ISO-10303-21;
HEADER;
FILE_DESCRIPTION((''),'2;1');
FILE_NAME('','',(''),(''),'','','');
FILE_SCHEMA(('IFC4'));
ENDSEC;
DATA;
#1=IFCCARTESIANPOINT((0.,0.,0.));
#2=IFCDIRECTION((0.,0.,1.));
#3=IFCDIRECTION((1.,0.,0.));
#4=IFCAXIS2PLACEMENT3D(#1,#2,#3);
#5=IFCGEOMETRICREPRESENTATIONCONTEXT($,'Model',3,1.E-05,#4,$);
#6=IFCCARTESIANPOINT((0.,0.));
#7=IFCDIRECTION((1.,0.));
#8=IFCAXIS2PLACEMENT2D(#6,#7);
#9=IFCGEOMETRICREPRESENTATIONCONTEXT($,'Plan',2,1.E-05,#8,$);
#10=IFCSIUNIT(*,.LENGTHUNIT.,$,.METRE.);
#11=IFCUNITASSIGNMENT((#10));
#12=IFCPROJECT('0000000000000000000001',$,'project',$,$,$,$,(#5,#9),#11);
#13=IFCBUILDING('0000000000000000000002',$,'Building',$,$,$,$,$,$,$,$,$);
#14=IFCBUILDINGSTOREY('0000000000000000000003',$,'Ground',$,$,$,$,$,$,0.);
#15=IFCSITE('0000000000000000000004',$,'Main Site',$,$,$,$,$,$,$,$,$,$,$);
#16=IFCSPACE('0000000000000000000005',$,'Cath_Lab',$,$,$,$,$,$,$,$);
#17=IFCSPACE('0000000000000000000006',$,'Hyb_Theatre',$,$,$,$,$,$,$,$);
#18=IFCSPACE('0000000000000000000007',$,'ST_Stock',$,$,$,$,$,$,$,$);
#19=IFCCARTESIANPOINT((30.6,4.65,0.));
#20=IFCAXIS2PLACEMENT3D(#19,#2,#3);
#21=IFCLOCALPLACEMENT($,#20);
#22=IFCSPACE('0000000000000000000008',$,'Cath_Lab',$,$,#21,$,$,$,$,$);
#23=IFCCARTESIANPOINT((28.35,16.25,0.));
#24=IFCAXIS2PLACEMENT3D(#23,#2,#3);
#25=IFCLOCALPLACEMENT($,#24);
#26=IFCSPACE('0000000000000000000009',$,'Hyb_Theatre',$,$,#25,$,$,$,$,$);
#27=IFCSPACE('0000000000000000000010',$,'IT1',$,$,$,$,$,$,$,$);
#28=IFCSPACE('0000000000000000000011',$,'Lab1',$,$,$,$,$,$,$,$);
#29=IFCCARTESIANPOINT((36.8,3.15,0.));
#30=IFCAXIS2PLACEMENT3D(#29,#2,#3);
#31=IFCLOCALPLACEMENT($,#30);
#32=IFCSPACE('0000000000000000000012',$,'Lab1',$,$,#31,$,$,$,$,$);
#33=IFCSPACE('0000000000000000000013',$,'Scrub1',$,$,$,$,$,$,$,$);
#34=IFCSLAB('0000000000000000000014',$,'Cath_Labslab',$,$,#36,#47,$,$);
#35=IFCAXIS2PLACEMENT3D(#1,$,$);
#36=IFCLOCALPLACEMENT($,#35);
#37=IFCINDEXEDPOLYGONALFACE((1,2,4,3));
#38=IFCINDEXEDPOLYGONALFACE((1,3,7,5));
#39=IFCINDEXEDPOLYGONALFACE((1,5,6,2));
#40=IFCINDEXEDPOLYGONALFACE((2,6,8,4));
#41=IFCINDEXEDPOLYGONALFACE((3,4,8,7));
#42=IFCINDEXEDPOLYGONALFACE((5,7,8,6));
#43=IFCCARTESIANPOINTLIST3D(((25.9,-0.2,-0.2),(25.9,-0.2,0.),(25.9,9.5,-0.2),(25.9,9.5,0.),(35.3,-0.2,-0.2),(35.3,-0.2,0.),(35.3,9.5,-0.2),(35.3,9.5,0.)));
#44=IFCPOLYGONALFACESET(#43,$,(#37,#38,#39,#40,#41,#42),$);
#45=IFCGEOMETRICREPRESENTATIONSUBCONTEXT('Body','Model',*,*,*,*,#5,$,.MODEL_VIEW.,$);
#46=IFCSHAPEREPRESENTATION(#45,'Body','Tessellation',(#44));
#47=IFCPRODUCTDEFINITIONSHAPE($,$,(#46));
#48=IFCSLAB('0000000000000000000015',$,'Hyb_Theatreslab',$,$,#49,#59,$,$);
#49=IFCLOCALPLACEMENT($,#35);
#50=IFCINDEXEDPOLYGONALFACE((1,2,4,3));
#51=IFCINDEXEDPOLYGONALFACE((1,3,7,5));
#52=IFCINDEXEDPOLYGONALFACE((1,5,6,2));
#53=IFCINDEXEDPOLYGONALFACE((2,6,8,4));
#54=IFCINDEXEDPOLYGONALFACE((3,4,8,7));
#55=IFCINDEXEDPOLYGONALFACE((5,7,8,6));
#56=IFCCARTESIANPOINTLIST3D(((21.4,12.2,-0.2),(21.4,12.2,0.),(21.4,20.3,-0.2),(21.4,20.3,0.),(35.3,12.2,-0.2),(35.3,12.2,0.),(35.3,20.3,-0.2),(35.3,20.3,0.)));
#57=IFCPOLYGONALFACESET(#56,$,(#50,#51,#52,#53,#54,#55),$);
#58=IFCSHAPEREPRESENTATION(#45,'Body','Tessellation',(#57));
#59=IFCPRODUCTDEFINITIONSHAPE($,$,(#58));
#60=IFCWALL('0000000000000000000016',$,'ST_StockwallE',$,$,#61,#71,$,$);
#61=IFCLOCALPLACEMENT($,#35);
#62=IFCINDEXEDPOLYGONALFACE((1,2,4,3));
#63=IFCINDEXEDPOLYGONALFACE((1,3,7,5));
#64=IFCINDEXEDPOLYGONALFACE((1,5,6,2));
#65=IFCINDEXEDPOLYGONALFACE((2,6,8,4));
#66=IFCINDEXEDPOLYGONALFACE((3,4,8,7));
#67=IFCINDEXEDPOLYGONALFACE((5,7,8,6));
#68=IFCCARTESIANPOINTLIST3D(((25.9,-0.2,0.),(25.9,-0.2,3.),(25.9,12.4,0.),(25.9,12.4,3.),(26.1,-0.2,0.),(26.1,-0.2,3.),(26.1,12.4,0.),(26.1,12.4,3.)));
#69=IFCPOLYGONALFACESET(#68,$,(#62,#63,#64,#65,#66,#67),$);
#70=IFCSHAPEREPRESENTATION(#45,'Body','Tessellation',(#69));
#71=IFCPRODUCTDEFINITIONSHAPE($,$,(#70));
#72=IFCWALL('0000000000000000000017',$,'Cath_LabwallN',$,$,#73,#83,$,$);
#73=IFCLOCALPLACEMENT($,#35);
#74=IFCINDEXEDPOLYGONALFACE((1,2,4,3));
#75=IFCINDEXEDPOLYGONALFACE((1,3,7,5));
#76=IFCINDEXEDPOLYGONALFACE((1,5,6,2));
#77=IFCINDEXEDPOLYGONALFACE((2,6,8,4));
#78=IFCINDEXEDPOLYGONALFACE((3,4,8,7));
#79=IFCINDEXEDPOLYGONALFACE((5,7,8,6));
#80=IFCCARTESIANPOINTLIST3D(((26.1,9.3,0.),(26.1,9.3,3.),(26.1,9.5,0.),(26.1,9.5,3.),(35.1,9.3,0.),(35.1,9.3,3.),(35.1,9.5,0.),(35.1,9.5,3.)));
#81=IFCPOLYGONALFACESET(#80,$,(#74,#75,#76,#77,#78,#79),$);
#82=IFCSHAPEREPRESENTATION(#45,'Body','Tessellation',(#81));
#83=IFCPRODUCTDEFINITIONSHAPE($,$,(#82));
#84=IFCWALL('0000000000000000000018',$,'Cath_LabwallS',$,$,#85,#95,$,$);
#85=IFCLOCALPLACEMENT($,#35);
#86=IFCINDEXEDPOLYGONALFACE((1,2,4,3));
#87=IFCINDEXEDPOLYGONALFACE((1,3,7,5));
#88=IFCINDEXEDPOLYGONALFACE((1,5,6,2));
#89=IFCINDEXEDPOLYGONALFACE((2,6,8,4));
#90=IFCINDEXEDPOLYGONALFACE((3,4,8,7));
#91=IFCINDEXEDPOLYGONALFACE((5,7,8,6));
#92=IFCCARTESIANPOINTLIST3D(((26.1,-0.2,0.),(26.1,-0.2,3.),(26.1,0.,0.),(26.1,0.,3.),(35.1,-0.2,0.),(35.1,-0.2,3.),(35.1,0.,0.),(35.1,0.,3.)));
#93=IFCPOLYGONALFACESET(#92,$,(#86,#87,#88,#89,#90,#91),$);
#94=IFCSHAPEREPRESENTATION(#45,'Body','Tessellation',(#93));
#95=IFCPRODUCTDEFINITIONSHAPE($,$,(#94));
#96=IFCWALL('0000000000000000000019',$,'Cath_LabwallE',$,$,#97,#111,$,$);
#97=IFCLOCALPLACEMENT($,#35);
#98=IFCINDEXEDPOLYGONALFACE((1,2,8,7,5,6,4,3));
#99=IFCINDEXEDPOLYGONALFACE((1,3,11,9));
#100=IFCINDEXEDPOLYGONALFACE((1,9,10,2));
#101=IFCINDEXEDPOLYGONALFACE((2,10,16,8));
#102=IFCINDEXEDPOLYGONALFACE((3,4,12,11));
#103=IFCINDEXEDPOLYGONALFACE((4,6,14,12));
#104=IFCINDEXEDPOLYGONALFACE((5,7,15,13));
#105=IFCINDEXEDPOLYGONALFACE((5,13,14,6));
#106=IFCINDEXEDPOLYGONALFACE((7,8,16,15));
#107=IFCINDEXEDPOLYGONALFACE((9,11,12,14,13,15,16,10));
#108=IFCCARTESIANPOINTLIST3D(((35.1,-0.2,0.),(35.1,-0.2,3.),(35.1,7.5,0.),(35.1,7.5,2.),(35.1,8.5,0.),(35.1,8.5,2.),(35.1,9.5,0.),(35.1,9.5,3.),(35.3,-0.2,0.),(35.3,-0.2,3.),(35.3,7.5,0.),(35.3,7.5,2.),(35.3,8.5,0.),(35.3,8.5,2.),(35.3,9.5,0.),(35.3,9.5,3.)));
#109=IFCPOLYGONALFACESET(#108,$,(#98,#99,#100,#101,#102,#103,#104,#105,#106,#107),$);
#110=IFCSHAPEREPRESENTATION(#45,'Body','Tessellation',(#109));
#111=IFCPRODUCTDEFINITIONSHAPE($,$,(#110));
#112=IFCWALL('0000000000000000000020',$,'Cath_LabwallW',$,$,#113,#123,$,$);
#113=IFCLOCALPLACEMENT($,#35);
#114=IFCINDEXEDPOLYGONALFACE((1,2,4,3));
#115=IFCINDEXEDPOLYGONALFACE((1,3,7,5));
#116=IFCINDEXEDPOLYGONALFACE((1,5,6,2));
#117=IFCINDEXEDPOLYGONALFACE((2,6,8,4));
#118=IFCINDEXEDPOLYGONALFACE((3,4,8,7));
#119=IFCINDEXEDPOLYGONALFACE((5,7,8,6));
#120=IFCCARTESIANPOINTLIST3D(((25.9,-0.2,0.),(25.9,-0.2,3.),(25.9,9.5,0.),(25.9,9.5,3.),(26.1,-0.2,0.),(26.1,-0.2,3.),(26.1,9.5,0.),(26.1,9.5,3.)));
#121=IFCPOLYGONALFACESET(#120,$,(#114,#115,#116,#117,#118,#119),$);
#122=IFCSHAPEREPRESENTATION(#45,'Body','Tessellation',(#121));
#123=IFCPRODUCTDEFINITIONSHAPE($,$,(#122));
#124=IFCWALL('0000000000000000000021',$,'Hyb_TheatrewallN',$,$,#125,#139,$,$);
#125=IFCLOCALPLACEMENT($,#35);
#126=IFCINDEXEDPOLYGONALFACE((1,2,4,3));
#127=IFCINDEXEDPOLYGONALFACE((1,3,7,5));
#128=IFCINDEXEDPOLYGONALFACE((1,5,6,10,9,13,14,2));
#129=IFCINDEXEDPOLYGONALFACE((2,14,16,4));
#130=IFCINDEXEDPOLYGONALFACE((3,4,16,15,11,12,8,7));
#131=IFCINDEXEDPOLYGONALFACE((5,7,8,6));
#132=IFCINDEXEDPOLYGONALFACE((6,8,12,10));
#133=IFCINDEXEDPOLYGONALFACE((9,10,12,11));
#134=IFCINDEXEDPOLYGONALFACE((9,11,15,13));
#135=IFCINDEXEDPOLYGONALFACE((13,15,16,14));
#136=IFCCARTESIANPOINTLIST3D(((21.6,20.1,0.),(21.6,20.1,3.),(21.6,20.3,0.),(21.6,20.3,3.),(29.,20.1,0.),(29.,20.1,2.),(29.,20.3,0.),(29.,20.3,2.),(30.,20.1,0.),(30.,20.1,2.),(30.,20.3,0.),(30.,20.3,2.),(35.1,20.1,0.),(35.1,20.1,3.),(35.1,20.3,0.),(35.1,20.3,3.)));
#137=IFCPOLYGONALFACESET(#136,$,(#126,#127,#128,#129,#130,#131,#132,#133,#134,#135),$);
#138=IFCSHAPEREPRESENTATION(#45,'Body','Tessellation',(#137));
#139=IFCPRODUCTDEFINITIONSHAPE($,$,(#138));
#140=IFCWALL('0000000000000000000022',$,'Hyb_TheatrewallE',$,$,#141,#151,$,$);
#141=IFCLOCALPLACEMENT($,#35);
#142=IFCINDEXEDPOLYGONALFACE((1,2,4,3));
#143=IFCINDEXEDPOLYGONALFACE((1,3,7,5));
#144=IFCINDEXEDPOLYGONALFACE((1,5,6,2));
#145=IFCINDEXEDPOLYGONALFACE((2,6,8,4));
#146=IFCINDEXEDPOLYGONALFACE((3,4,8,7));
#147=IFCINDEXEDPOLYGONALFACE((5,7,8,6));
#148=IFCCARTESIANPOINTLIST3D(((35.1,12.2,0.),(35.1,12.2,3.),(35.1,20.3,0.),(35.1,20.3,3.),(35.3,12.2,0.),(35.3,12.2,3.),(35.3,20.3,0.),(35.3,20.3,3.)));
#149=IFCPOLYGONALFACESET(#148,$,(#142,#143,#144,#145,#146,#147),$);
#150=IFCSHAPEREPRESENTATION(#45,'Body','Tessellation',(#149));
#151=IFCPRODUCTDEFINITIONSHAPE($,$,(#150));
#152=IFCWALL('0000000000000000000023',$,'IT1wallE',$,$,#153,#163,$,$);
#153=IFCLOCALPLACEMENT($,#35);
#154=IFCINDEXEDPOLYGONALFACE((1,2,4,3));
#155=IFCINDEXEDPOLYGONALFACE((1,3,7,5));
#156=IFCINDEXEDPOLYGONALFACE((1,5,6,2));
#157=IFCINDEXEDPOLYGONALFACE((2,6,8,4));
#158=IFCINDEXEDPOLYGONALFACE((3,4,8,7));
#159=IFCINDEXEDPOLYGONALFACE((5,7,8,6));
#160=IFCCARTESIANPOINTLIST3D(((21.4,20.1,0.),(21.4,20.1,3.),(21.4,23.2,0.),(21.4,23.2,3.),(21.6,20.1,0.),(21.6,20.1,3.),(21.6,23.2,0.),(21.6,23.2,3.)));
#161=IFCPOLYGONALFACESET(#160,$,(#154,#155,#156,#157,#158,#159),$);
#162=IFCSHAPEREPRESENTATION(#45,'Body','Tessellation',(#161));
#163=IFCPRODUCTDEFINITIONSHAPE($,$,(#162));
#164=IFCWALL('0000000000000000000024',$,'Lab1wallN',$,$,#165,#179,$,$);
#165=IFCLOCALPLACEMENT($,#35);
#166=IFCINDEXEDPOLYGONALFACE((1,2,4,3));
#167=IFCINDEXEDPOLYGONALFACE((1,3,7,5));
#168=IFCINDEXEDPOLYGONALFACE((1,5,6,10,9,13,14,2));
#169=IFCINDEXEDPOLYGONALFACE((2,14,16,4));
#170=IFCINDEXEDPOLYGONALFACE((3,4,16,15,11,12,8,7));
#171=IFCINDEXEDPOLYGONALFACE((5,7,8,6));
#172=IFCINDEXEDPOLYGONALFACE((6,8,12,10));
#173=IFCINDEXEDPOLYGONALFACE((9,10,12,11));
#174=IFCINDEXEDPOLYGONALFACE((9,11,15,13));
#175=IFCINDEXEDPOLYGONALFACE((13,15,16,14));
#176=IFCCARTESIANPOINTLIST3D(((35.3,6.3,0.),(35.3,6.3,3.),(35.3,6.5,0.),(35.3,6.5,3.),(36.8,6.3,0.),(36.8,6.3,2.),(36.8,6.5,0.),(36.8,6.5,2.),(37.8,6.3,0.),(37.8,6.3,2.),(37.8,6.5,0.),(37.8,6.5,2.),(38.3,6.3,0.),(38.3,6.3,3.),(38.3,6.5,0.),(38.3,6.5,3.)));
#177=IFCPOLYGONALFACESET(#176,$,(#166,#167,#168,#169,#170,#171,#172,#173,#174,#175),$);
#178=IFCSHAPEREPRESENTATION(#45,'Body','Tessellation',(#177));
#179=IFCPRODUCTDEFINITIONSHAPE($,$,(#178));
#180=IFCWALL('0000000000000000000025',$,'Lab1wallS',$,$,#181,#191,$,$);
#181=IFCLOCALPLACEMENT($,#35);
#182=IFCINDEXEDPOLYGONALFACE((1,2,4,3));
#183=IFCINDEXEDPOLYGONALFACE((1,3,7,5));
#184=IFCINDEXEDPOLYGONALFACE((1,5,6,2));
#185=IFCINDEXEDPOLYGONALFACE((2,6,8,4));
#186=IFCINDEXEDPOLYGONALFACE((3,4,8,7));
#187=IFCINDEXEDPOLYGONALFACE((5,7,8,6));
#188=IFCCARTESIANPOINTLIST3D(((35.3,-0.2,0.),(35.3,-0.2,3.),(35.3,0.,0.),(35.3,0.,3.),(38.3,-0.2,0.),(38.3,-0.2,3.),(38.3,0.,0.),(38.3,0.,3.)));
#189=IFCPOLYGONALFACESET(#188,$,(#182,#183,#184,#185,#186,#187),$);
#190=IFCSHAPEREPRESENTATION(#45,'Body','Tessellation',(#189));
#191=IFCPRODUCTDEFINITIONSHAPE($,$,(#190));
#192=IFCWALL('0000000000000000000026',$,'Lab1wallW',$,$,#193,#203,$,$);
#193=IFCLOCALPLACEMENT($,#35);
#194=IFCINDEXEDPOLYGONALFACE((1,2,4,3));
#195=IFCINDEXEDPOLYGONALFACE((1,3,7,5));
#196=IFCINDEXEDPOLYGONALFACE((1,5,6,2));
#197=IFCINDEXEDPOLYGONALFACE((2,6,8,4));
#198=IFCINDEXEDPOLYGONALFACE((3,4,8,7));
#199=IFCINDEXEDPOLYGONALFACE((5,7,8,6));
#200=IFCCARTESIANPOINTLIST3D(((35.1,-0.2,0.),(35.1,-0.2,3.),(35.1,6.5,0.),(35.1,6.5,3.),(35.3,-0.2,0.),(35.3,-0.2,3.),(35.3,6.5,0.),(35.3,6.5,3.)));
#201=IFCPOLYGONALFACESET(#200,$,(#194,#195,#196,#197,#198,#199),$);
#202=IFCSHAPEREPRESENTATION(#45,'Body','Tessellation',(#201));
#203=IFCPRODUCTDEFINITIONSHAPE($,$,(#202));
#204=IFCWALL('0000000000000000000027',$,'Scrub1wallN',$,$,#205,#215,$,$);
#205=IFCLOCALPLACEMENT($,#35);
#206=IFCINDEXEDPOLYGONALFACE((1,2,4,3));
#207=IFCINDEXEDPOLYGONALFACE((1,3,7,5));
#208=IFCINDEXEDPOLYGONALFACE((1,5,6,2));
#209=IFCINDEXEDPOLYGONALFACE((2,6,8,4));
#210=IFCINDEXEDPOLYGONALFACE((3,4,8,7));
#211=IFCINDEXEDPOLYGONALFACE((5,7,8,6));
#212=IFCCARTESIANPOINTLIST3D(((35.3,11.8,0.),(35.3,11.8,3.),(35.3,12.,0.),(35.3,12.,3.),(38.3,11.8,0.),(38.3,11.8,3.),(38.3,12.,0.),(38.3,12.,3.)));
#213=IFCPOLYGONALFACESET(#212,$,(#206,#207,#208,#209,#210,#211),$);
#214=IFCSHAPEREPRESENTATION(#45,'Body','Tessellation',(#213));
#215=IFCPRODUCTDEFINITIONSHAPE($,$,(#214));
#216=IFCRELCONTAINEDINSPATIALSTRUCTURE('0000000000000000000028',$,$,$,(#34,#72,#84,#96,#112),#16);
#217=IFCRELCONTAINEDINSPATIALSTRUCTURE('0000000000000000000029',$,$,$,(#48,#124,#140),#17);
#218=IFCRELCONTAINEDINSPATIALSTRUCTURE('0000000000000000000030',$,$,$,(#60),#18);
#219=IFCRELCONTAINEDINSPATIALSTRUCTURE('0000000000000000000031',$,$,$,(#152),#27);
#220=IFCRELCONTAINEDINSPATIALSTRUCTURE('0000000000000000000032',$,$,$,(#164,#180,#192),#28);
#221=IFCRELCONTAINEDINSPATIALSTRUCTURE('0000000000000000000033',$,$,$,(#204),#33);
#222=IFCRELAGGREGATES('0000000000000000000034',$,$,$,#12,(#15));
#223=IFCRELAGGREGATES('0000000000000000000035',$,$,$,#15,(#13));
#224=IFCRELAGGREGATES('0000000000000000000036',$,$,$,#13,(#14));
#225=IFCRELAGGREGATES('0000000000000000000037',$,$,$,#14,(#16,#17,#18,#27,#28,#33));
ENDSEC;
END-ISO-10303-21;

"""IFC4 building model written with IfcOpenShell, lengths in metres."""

from ifc_helpers import new_model, si_unit, frame, origin_with_axes, origin_2d_with_axis, place, context, subcontext, project, spatial, indexed_curve, rectangle, outline, extrude, element, save


model = new_model("IFC4")

# Units and contexts
model_context = context("Model", 3, precision=1e-05, world=origin_with_axes())
plan_context = context("Plan", 2, precision=1e-05, world=origin_2d_with_axis())
body_context = subcontext(model_context, "Body", "Model", "MODEL_VIEW")
ifc_project = project(units=[si_unit("LENGTHUNIT", "METRE")], contexts=[model_context, plan_context])

# Site, building, storey, space
site = spatial("IfcSite", under=ifc_project, Name="Main Site")
building = spatial("IfcBuilding", under=site, Name="Building")
storey = spatial("IfcBuildingStorey", under=building, Name="Ground", Elevation=0.0)
space_1 = spatial("IfcSpace", under=storey, Name="Cath_Lab")

# Slab
slab_1_placement = place(None, frame((30.6, 4.65, -0.2), z_axis=(0.0, 0.0, 1.0), x_axis=(1.0, 0.0, 0.0)))
element("IfcSlab", 1, at=slab_1_placement, inside=space_1, Name="Cath_Labslab", context=body_context, shape_type="SweptSolid", body=[
    extrude(rectangle(XDim=9.4, YDim=9.7), origin_with_axes(), (0.0, 0.0, 1.0), 0.2),
])

# Shared definitions
space_2 = spatial("IfcSpace", under=storey, Name="Hyb_Theatre")

# Slab
slab_2_placement = place(None, frame((28.35, 16.25, -0.2), z_axis=(0.0, 0.0, 1.0), x_axis=(1.0, 0.0, 0.0)))
element("IfcSlab", 2, at=slab_2_placement, inside=space_2, Name="Hyb_Theatreslab", context=body_context, shape_type="SweptSolid", body=[
    extrude(rectangle(XDim=13.9, YDim=8.1), origin_with_axes(), (0.0, 0.0, 1.0), 0.2),
])

# Shared definitions
space_3 = spatial("IfcSpace", under=storey, Name="ST_Stock")

# Walls
wall_1_placement = place(None, frame((26.1, -0.2, 0.0), z_axis=(0.0, 0.0, 1.0), x_axis=(0.0, 1.0, 0.0)))
element("IfcWall", 3, at=wall_1_placement, inside=space_3, Name="ST_StockwallE", context=body_context, shape_type="SweptSolid", body=[
    extrude(outline(indexed_curve([(0.0, 0.0), (0.0, 0.2), (12.6, 0.2), (12.6, 0.0), (0.0, 0.0)], self_intersect=False)), origin_with_axes(), (0.0, 0.0, 1.0), 3.0),
])
for number, where, z_axis, x_axis, name in (
    (4, (26.1, 9.3, 0.0), (0.0, 0.0, 1.0), (1.0, 0.0, 0.0), "Cath_LabwallN"),
    (5, (26.1, -0.2, 0.0), (0.0, 0.0, 1.0), (1.0, 0.0, 0.0), "Cath_LabwallS"),
):
    element("IfcWall", number, at=place(None, frame(where, z_axis=z_axis, x_axis=x_axis)), inside=space_1, Name=name, context=body_context, shape_type="SweptSolid", body=[
        extrude(outline(indexed_curve([(0.0, 0.0), (0.0, 0.2), (9.0, 0.2), (9.0, 0.0), (0.0, 0.0)], self_intersect=False)), origin_with_axes(), (0.0, 0.0, 1.0), 3.0),
    ])

# Wall
wall_2_placement = place(None, frame((35.3, -0.2, 0.0), z_axis=(0.0, 0.0, 1.0), x_axis=(0.0, 1.0, 0.0)))
wall_2 = element("IfcWall", 6, at=wall_2_placement, inside=space_1, Name="Cath_LabwallE", context=body_context, shape_type="SweptSolid", body=[
    extrude(outline(indexed_curve([(0.0, 0.0), (0.0, 0.2), (9.7, 0.2), (9.7, 0.0), (0.0, 0.0)], self_intersect=False)), origin_with_axes(), (0.0, 0.0, 1.0), 3.0),
])

# Shared definitions
space_4_placement = place(None, frame((30.6, 4.65, 0.0), z_axis=(0.0, 0.0, 1.0), x_axis=(1.0, 0.0, 0.0)))
space_4 = spatial("IfcSpace", at=space_4_placement, Name="Cath_Lab")

# Opening
opening_1_placement = place(wall_2_placement, frame((7.7, 0.0, 0.0), z_axis=(0.0, 0.0, 1.0), x_axis=(1.0, 0.0, 0.0)))
element("IfcOpeningElement", 7, at=opening_1_placement, inside=space_4, cuts=wall_2, context=body_context, shape_type="SweptSolid", body=[
    extrude(outline(indexed_curve([(0.0, 0.0), (0.0, 0.4), (1.0, 0.4), (1.0, 0.0), (0.0, 0.0)], self_intersect=False)), origin_with_axes(), (0.0, 0.0, 1.0), 2.0),
])

# Walls
wall_3_placement = place(None, frame((26.1, -0.2, 0.0), z_axis=(0.0, 0.0, 1.0), x_axis=(0.0, 1.0, 0.0)))
element("IfcWall", 8, at=wall_3_placement, inside=space_1, Name="Cath_LabwallW", context=body_context, shape_type="SweptSolid", body=[
    extrude(outline(indexed_curve([(0.0, 0.0), (0.0, 0.2), (9.7, 0.2), (9.7, 0.0), (0.0, 0.0)], self_intersect=False)), origin_with_axes(), (0.0, 0.0, 1.0), 3.0),
])
wall_4_placement = place(None, frame((21.6, 20.1, 0.0), z_axis=(0.0, 0.0, 1.0), x_axis=(1.0, 0.0, 0.0)))
wall_4 = element("IfcWall", 9, at=wall_4_placement, inside=space_2, Name="Hyb_TheatrewallN", context=body_context, shape_type="SweptSolid", body=[
    extrude(outline(indexed_curve([(0.0, 0.0), (0.0, 0.2), (13.5, 0.2), (13.5, 0.0), (0.0, 0.0)], self_intersect=False)), origin_with_axes(), (0.0, 0.0, 1.0), 3.0),
])

# Shared definitions
space_5_placement = place(None, frame((28.35, 16.25, 0.0), z_axis=(0.0, 0.0, 1.0), x_axis=(1.0, 0.0, 0.0)))
space_5 = spatial("IfcSpace", at=space_5_placement, Name="Hyb_Theatre")

# Opening
opening_2_placement = place(wall_4_placement, frame((7.4, 0.0, 0.0), z_axis=(0.0, 0.0, 1.0), x_axis=(1.0, 0.0, 0.0)))
element("IfcOpeningElement", 10, at=opening_2_placement, inside=space_5, cuts=wall_4, context=body_context, shape_type="SweptSolid", body=[
    extrude(outline(indexed_curve([(0.0, 0.0), (0.0, 0.4), (1.0, 0.4), (1.0, 0.0), (0.0, 0.0)], self_intersect=False)), origin_with_axes(), (0.0, 0.0, 1.0), 2.0),
])

# Wall
wall_5_placement = place(None, frame((35.3, 12.2, 0.0), z_axis=(0.0, 0.0, 1.0), x_axis=(0.0, 1.0, 0.0)))
element("IfcWall", 11, at=wall_5_placement, inside=space_2, Name="Hyb_TheatrewallE", context=body_context, shape_type="SweptSolid", body=[
    extrude(outline(indexed_curve([(0.0, 0.0), (0.0, 0.2), (8.1, 0.2), (8.1, 0.0), (0.0, 0.0)], self_intersect=False)), origin_with_axes(), (0.0, 0.0, 1.0), 3.0),
])

# Shared definitions
space_6 = spatial("IfcSpace", under=storey, Name="IT1")

# Wall
wall_6_placement = place(None, frame((21.6, 20.1, 0.0), z_axis=(0.0, 0.0, 1.0), x_axis=(0.0, 1.0, 0.0)))
element("IfcWall", 12, at=wall_6_placement, inside=space_6, Name="IT1wallE", context=body_context, shape_type="SweptSolid", body=[
    extrude(outline(indexed_curve([(0.0, 0.0), (0.0, 0.2), (3.1, 0.2), (3.1, 0.0), (0.0, 0.0)], self_intersect=False)), origin_with_axes(), (0.0, 0.0, 1.0), 3.0),
])

# Shared definitions
space_7 = spatial("IfcSpace", under=storey, Name="Lab1")

# Wall
wall_7_placement = place(None, frame((35.3, 6.3, 0.0), z_axis=(0.0, 0.0, 1.0), x_axis=(1.0, 0.0, 0.0)))
wall_7 = element("IfcWall", 13, at=wall_7_placement, inside=space_7, Name="Lab1wallN", context=body_context, shape_type="SweptSolid", body=[
    extrude(outline(indexed_curve([(0.0, 0.0), (0.0, 0.2), (3.0, 0.2), (3.0, 0.0), (0.0, 0.0)], self_intersect=False)), origin_with_axes(), (0.0, 0.0, 1.0), 3.0),
])

# Shared definitions
space_8_placement = place(None, frame((36.8, 3.15, 0.0), z_axis=(0.0, 0.0, 1.0), x_axis=(1.0, 0.0, 0.0)))
space_8 = spatial("IfcSpace", at=space_8_placement, Name="Lab1")

# Opening
opening_3_placement = place(wall_7_placement, frame((1.5, 0.0, 0.0), z_axis=(0.0, 0.0, 1.0), x_axis=(1.0, 0.0, 0.0)))
element("IfcOpeningElement", 14, at=opening_3_placement, inside=space_8, cuts=wall_7, context=body_context, shape_type="SweptSolid", body=[
    extrude(outline(indexed_curve([(0.0, 0.0), (0.0, 0.4), (1.0, 0.4), (1.0, 0.0), (0.0, 0.0)], self_intersect=False)), origin_with_axes(), (0.0, 0.0, 1.0), 2.0),
])

# Walls
wall_8_placement = place(None, frame((35.3, -0.2, 0.0), z_axis=(0.0, 0.0, 1.0), x_axis=(1.0, 0.0, 0.0)))
element("IfcWall", 15, at=wall_8_placement, inside=space_7, Name="Lab1wallS", context=body_context, shape_type="SweptSolid", body=[
    extrude(outline(indexed_curve([(0.0, 0.0), (0.0, 0.2), (3.0, 0.2), (3.0, 0.0), (0.0, 0.0)], self_intersect=False)), origin_with_axes(), (0.0, 0.0, 1.0), 3.0),
])
wall_9_placement = place(None, frame((35.3, -0.2, 0.0), z_axis=(0.0, 0.0, 1.0), x_axis=(0.0, 1.0, 0.0)))
element("IfcWall", 16, at=wall_9_placement, inside=space_7, Name="Lab1wallW", context=body_context, shape_type="SweptSolid", body=[
    extrude(outline(indexed_curve([(0.0, 0.0), (0.0, 0.2), (6.7, 0.2), (6.7, 0.0), (0.0, 0.0)], self_intersect=False)), origin_with_axes(), (0.0, 0.0, 1.0), 3.0),
])

# Shared definitions
space_9 = spatial("IfcSpace", under=storey, Name="Scrub1")

# Wall
wall_10_placement = place(None, frame((35.3, 11.8, 0.0), z_axis=(0.0, 0.0, 1.0), x_axis=(1.0, 0.0, 0.0)))
element("IfcWall", 17, at=wall_10_placement, inside=space_9, Name="Scrub1wallN", context=body_context, shape_type="SweptSolid", body=[
    extrude(outline(indexed_curve([(0.0, 0.0), (0.0, 0.2), (3.0, 0.2), (3.0, 0.0), (0.0, 0.0)], self_intersect=False)), origin_with_axes(), (0.0, 0.0, 1.0), 3.0),
])

save(model, "model.ifc")
